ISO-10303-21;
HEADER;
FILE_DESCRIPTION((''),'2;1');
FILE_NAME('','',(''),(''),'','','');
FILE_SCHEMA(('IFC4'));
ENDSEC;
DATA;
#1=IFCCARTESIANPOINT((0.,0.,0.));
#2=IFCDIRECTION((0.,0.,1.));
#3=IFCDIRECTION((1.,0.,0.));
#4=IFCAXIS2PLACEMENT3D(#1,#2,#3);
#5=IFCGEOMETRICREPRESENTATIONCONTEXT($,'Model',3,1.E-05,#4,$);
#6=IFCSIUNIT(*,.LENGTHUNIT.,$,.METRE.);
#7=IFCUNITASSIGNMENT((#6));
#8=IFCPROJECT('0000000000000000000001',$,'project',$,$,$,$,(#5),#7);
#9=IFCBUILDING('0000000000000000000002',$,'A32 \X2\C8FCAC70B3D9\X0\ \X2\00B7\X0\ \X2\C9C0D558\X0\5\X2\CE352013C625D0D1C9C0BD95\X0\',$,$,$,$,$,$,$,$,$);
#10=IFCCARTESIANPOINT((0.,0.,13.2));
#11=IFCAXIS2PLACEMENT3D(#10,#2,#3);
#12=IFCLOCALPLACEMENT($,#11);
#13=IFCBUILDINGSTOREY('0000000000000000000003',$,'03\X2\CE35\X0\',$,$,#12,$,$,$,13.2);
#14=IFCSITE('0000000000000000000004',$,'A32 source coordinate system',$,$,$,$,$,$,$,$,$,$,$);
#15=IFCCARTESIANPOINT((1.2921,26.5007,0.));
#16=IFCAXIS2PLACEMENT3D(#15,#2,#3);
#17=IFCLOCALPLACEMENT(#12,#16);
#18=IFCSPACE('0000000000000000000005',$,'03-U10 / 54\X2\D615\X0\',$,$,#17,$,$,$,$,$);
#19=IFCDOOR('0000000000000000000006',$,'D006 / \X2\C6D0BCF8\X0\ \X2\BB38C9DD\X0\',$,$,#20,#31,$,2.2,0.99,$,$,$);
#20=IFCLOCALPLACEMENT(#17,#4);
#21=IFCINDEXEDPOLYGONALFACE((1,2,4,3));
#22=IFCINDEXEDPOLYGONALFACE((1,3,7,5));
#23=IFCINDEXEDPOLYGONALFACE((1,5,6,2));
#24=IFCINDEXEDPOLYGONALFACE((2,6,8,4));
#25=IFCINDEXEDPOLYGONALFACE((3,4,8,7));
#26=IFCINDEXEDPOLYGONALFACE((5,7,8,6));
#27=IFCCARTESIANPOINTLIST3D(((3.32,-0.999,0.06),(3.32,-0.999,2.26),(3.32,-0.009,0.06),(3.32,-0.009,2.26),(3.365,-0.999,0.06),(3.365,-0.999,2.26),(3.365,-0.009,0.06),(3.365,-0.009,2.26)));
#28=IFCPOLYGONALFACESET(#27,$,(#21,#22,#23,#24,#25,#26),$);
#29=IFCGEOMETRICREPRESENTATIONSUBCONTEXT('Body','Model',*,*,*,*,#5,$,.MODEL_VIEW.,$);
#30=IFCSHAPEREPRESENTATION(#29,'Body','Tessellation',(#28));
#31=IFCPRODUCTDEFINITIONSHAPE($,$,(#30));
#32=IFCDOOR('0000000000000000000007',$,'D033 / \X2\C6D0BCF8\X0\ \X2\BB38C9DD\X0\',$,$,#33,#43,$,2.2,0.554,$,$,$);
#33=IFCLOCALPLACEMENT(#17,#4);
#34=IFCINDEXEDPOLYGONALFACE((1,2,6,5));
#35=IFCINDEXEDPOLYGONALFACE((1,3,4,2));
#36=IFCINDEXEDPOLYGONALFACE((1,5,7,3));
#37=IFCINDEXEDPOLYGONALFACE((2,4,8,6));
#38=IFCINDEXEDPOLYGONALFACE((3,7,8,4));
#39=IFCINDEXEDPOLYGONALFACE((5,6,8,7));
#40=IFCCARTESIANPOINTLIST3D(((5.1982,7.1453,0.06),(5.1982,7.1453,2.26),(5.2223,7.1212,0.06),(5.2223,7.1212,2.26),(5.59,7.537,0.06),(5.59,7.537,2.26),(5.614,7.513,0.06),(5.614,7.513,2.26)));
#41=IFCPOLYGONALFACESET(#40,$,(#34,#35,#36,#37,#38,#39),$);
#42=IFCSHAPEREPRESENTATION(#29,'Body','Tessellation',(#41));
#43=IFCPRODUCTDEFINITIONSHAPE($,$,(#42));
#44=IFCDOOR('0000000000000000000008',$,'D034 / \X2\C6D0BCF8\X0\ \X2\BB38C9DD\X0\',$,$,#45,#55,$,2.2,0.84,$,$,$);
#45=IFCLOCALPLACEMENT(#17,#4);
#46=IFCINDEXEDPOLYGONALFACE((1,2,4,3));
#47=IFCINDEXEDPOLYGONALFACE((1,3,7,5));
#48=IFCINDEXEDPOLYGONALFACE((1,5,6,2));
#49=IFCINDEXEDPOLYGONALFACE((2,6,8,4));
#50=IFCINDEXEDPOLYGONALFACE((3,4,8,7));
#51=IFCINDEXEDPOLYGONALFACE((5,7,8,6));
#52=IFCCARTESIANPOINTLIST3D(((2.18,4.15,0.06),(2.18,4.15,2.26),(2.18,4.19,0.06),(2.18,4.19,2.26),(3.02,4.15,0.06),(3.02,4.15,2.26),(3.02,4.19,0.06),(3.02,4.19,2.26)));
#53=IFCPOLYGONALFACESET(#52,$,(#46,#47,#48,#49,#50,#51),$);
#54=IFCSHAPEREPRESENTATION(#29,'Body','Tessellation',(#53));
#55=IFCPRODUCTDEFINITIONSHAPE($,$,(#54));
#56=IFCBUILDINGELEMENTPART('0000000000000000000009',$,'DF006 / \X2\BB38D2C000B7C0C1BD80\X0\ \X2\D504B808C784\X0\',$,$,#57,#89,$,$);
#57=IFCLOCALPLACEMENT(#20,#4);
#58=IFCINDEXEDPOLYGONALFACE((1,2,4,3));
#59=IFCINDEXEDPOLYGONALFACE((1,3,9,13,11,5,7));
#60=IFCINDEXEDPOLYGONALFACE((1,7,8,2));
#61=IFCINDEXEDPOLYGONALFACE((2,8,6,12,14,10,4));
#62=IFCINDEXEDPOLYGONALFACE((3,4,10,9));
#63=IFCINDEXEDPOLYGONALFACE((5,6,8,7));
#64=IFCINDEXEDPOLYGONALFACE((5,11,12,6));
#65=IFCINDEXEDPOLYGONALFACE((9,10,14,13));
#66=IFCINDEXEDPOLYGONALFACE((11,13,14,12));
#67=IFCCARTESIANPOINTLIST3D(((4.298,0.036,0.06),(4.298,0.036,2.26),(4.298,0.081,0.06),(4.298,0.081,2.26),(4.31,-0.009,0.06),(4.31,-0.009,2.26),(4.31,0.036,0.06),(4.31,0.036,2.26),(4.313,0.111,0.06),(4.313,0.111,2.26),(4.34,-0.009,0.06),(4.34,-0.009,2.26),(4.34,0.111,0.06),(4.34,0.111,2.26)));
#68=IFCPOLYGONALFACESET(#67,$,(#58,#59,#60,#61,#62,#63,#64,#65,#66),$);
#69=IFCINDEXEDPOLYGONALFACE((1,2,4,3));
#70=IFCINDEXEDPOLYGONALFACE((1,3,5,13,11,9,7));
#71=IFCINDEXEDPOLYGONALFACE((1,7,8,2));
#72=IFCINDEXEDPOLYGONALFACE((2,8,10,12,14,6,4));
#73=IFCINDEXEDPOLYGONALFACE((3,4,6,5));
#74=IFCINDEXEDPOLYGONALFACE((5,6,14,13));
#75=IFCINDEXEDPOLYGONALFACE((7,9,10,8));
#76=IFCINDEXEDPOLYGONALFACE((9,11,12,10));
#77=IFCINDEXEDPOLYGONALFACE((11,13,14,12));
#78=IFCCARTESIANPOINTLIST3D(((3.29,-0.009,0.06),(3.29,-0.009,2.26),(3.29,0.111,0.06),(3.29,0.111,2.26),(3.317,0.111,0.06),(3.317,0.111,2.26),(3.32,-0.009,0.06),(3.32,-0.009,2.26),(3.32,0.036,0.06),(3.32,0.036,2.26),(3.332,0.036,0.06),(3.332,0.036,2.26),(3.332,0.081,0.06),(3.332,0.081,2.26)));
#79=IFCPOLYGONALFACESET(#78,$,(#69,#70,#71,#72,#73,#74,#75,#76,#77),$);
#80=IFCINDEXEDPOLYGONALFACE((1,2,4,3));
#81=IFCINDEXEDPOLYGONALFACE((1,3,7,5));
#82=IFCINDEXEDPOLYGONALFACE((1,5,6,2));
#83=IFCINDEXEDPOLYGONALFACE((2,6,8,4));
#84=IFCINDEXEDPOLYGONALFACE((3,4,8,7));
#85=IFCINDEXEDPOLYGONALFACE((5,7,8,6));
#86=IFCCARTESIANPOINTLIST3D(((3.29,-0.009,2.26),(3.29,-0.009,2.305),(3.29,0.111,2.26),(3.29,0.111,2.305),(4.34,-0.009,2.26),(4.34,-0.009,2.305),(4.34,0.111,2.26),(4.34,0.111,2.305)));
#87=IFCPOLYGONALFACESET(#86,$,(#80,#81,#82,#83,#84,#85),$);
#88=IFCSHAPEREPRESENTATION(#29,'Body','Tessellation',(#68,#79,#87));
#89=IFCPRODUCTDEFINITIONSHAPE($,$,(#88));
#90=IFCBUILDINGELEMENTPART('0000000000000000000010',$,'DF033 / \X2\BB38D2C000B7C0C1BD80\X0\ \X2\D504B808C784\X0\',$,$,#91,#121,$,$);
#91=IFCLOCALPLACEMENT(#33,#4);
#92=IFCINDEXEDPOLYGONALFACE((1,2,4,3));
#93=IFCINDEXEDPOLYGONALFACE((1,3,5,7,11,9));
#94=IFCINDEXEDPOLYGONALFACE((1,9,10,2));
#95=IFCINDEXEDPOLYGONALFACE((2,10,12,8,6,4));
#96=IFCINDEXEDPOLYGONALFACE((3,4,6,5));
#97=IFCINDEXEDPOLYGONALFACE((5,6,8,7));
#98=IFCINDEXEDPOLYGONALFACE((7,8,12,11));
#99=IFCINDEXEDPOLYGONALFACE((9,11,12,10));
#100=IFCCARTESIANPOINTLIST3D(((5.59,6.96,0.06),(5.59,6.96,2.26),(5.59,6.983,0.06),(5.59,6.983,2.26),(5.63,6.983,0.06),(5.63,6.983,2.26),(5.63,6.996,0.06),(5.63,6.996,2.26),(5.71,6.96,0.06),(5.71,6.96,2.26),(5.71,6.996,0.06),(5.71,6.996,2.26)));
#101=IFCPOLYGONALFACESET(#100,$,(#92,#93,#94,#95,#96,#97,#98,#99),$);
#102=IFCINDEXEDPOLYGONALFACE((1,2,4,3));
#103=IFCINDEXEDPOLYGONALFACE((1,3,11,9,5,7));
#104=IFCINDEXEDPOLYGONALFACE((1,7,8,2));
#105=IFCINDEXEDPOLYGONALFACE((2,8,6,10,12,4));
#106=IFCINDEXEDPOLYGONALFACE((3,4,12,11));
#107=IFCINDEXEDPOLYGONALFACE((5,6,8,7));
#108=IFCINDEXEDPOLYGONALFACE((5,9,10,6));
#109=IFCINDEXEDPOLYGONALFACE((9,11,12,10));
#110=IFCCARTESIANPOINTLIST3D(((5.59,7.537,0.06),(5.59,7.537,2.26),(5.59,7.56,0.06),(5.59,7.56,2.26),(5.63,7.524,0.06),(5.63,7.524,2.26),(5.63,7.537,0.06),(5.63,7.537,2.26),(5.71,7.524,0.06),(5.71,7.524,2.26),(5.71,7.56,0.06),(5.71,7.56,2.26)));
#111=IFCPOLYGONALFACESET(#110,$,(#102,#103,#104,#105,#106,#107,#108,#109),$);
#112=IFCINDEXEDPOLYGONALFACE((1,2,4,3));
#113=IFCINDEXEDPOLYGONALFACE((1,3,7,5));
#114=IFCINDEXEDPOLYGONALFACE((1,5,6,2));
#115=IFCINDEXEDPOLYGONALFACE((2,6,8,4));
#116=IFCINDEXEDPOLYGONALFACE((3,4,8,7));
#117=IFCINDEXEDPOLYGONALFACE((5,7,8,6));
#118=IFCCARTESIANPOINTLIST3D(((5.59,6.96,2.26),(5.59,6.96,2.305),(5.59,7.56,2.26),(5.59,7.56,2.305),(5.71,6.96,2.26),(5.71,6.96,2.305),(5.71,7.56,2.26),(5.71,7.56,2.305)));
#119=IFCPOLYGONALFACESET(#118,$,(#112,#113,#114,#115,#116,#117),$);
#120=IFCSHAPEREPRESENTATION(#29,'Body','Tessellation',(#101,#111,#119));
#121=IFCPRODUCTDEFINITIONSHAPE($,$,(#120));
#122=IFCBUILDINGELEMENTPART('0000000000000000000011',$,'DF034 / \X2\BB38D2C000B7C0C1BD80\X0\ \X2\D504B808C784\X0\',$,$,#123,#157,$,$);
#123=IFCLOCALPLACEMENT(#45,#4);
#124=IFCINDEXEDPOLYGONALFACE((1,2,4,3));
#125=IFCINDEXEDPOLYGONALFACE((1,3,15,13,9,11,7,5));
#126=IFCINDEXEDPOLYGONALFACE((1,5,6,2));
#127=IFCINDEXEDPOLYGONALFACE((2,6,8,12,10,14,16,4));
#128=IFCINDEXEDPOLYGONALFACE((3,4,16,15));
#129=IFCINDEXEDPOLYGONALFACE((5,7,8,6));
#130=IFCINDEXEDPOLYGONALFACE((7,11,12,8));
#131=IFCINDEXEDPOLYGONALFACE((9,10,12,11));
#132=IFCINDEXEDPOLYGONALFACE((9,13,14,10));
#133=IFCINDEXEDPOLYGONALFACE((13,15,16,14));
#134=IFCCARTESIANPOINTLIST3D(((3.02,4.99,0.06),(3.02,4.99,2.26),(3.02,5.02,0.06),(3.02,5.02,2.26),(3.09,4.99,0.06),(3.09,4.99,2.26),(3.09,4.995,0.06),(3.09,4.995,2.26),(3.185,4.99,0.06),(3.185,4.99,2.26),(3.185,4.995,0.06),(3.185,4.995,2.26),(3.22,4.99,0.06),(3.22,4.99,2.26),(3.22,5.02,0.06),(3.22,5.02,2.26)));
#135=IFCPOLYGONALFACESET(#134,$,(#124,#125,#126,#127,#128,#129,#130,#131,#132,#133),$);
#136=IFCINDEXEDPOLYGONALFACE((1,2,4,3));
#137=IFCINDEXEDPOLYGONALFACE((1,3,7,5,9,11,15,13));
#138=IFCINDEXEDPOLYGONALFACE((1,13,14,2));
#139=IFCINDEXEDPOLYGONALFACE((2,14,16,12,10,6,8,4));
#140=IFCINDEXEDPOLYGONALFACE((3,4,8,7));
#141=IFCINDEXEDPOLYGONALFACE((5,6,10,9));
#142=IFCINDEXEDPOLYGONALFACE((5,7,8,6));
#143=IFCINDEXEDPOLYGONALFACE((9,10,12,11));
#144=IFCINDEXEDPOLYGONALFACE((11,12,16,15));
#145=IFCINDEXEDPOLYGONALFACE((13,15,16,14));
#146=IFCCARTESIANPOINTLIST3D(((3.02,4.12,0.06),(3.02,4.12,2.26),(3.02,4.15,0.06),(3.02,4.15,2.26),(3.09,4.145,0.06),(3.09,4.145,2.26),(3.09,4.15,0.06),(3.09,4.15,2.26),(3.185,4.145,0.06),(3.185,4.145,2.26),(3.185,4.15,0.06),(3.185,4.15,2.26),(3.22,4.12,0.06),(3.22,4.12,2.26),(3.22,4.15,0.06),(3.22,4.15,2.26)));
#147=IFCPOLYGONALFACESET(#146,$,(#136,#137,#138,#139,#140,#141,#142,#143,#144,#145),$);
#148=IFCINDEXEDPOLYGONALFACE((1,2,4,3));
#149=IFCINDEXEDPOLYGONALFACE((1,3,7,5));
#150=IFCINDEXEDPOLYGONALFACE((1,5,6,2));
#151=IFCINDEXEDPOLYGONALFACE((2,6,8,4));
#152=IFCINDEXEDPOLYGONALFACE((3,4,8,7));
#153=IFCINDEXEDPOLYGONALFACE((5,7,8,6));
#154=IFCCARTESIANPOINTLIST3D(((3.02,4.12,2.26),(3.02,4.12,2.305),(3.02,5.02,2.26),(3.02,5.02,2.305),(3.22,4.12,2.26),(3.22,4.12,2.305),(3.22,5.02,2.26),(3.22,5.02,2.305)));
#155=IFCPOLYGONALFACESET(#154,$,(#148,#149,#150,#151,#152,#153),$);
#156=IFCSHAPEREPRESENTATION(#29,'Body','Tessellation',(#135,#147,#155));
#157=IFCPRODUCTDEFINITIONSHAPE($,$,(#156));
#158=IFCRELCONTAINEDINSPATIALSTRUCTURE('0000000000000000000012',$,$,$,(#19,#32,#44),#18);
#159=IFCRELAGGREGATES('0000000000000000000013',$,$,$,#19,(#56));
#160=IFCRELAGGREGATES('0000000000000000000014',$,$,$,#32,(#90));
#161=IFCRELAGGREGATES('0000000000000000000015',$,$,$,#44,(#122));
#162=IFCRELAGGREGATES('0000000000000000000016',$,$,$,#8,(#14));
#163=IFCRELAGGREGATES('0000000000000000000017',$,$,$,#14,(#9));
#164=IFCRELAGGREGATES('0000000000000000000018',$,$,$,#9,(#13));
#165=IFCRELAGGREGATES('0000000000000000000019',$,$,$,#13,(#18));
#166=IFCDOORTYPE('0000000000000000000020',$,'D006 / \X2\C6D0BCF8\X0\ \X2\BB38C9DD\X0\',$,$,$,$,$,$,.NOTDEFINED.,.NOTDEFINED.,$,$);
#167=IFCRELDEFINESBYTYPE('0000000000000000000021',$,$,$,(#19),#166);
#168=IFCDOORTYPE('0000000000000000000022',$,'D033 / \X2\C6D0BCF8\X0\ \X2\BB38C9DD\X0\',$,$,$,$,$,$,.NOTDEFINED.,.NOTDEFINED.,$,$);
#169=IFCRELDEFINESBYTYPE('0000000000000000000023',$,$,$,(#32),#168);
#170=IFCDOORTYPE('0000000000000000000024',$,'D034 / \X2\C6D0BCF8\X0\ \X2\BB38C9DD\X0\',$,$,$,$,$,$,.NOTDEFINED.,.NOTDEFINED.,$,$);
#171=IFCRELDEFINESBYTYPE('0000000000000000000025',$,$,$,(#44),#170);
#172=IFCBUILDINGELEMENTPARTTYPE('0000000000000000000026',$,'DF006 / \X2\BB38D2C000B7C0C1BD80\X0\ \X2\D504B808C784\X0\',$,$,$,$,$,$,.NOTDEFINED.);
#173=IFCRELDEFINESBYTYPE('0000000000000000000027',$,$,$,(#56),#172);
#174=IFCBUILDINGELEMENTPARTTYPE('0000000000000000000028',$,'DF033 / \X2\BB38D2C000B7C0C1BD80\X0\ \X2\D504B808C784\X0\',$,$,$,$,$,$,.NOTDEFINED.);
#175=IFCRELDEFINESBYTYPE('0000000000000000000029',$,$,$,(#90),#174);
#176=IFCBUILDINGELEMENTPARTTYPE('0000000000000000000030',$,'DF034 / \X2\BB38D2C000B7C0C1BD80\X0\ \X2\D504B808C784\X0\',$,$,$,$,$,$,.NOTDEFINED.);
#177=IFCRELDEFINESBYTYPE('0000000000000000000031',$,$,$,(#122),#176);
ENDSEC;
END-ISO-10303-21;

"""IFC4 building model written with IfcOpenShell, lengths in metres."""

from ifc_helpers import new_model, si_unit, frame, origin, origin_with_axes, place, context, subcontext, project, spatial, polyline, outline, extrude, source, transform, mapped, type_object, type_shapes, element, aggregate, save


model = new_model("IFC4")

# Units and contexts
model_context = context("Model", 3, precision=1e-05, world=origin_with_axes())
body_context = subcontext(model_context, "Body", "Model", "MODEL_VIEW")
ifc_project = project(units=[si_unit("LENGTHUNIT", "METRE")], contexts=[model_context])

# Site, building, storey, space
storey_placement = place(None, frame((0.0, 0.0, 13.2), z_axis=(0.0, 0.0, 1.0), x_axis=(1.0, 0.0, 0.0)))
space_1_placement = place(storey_placement, frame((1.2921, 26.5007, 0.0), z_axis=(0.0, 0.0, 1.0), x_axis=(1.0, 0.0, 0.0)))
site = spatial("IfcSite", under=ifc_project, Name="A32 source coordinate system")
building = spatial("IfcBuilding", under=site, Name="A32 주거동 · 지하5층–옥탑지붕")
storey = spatial("IfcBuildingStorey", under=building, at=storey_placement, Name="03층", Elevation=13.2)
space_1 = spatial("IfcSpace", under=storey, at=space_1_placement, Name="03-U10 / 54형")

# Doors
door_type_1 = type_object("IfcDoorType", Name="D006 / 원본 문짝", OperationType="NOTDEFINED", PredefinedType="NOTDEFINED")
shared_shape_1 = source(origin(), body_context, "Body", "SweptSolid", [
    extrude(outline(polyline([(3.365, -0.999), (3.32, -0.999), (3.32, -0.009), (3.365, -0.009), (3.365, -0.999)])), frame((0.0, 0.0, 0.06)), (0.0, 0.0, 1.0), 2.2),
])
type_shapes(door_type_1, [shared_shape_1])
door_1_placement = place(space_1_placement, origin_with_axes())
door_1 = element("IfcDoor", 1, at=door_1_placement, inside=space_1, type_object=door_type_1, Name="D006 / 원본 문짝", OverallHeight=2.2, OverallWidth=0.99, context=body_context, shape_type="MappedRepresentation", body=[
    mapped(shared_shape_1, transform((0.0, 0.0, 0.0), scale=1.0)),
])
door_type_2 = type_object("IfcDoorType", Name="D033 / 원본 문짝", OperationType="NOTDEFINED", PredefinedType="NOTDEFINED")
shared_shape_2 = source(origin(), body_context, "Body", "SweptSolid", [
    extrude(outline(polyline([(5.2223, 7.1212), (5.1982, 7.1453), (5.59, 7.537), (5.614, 7.513), (5.2223, 7.1212)])), frame((0.0, 0.0, 0.06)), (0.0, 0.0, 1.0), 2.2),
])
type_shapes(door_type_2, [shared_shape_2])
door_2_placement = place(space_1_placement, origin_with_axes())
door_2 = element("IfcDoor", 2, at=door_2_placement, inside=space_1, type_object=door_type_2, Name="D033 / 원본 문짝", OverallHeight=2.2, OverallWidth=0.554, context=body_context, shape_type="MappedRepresentation", body=[
    mapped(shared_shape_2, transform((0.0, 0.0, 0.0), scale=1.0)),
])
door_type_3 = type_object("IfcDoorType", Name="D034 / 원본 문짝", OperationType="NOTDEFINED", PredefinedType="NOTDEFINED")
shared_shape_3 = source(origin(), body_context, "Body", "SweptSolid", [
    extrude(outline(polyline([(3.02, 4.15), (2.18, 4.15), (2.18, 4.19), (3.02, 4.19), (3.02, 4.15)])), frame((0.0, 0.0, 0.06)), (0.0, 0.0, 1.0), 2.2),
])
type_shapes(door_type_3, [shared_shape_3])
door_3_placement = place(space_1_placement, origin_with_axes())
door_3 = element("IfcDoor", 3, at=door_3_placement, inside=space_1, type_object=door_type_3, Name="D034 / 원본 문짝", OverallHeight=2.2, OverallWidth=0.84, context=body_context, shape_type="MappedRepresentation", body=[
    mapped(shared_shape_3, transform((0.0, 0.0, 0.0), scale=1.0)),
])

# Building element parts
building_element_part_type_1 = type_object("IfcBuildingElementPartType", Name="DF006 / 문틀·상부 프레임", PredefinedType="NOTDEFINED")
shared_shape_4 = source(origin(), body_context, "Body", "SweptSolid", [
    extrude(outline(polyline([(4.31, -0.009), (4.31, 0.036), (4.298, 0.036), (4.298, 0.081), (4.313, 0.111), (4.34, 0.111), (4.34, -0.009), (4.31, -0.009)])), frame((0.0, 0.0, 0.06)), (0.0, 0.0, 1.0), 2.2),
    extrude(outline(polyline([(3.29, 0.111), (3.317, 0.111), (3.332, 0.081), (3.332, 0.036), (3.32, 0.036), (3.32, -0.009), (3.29, -0.009), (3.29, 0.111)])), frame((0.0, 0.0, 0.06)), (0.0, 0.0, 1.0), 2.2),
    extrude(outline(polyline([(3.29, -0.009), (3.29, 0.111), (4.34, 0.111), (4.34, -0.009), (3.29, -0.009)])), frame((0.0, 0.0, 2.26)), (0.0, 0.0, 1.0), 0.045),
])
type_shapes(building_element_part_type_1, [shared_shape_4])
building_element_part_1_placement = place(door_1_placement, origin_with_axes())
building_element_part_1 = element("IfcBuildingElementPart", 4, at=building_element_part_1_placement, type_object=building_element_part_type_1, Name="DF006 / 문틀·상부 프레임", context=body_context, shape_type="MappedRepresentation", body=[
    mapped(shared_shape_4, transform((0.0, 0.0, 0.0), scale=1.0)),
])
aggregate(door_1, [building_element_part_1])
building_element_part_type_2 = type_object("IfcBuildingElementPartType", Name="DF033 / 문틀·상부 프레임", PredefinedType="NOTDEFINED")
shared_shape_5 = source(origin(), body_context, "Body", "SweptSolid", [
    extrude(outline(polyline([(5.59, 6.96), (5.59, 6.983), (5.63, 6.983), (5.63, 6.996), (5.71, 6.996), (5.71, 6.96), (5.59, 6.96)])), frame((0.0, 0.0, 0.06)), (0.0, 0.0, 1.0), 2.2),
    extrude(outline(polyline([(5.71, 7.524), (5.63, 7.524), (5.63, 7.537), (5.59, 7.537), (5.59, 7.56), (5.71, 7.56), (5.71, 7.524)])), frame((0.0, 0.0, 0.06)), (0.0, 0.0, 1.0), 2.2),
    extrude(outline(polyline([(5.59, 6.96), (5.59, 7.56), (5.71, 7.56), (5.71, 6.96), (5.59, 6.96)])), frame((0.0, 0.0, 2.26)), (0.0, 0.0, 1.0), 0.045),
])
type_shapes(building_element_part_type_2, [shared_shape_5])
building_element_part_2_placement = place(door_2_placement, origin_with_axes())
building_element_part_2 = element("IfcBuildingElementPart", 5, at=building_element_part_2_placement, type_object=building_element_part_type_2, Name="DF033 / 문틀·상부 프레임", context=body_context, shape_type="MappedRepresentation", body=[
    mapped(shared_shape_5, transform((0.0, 0.0, 0.0), scale=1.0)),
])
aggregate(door_2, [building_element_part_2])
building_element_part_type_3 = type_object("IfcBuildingElementPartType", Name="DF034 / 문틀·상부 프레임", PredefinedType="NOTDEFINED")
shared_shape_6 = source(origin(), body_context, "Body", "SweptSolid", [
    extrude(outline(polyline([(3.22, 5.02), (3.22, 4.99), (3.185, 4.99), (3.185, 4.995), (3.09, 4.995), (3.09, 4.99), (3.02, 4.99), (3.02, 5.02), (3.22, 5.02)])), frame((0.0, 0.0, 0.06)), (0.0, 0.0, 1.0), 2.2),
    extrude(outline(polyline([(3.02, 4.15), (3.09, 4.15), (3.09, 4.145), (3.185, 4.145), (3.185, 4.15), (3.22, 4.15), (3.22, 4.12), (3.02, 4.12), (3.02, 4.15)])), frame((0.0, 0.0, 0.06)), (0.0, 0.0, 1.0), 2.2),
    extrude(outline(polyline([(3.02, 4.12), (3.02, 5.02), (3.22, 5.02), (3.22, 4.12), (3.02, 4.12)])), frame((0.0, 0.0, 2.26)), (0.0, 0.0, 1.0), 0.045),
])
type_shapes(building_element_part_type_3, [shared_shape_6])
building_element_part_3_placement = place(door_3_placement, origin_with_axes())
building_element_part_3 = element("IfcBuildingElementPart", 6, at=building_element_part_3_placement, type_object=building_element_part_type_3, Name="DF034 / 문틀·상부 프레임", context=body_context, shape_type="MappedRepresentation", body=[
    mapped(shared_shape_6, transform((0.0, 0.0, 0.0), scale=1.0)),
])
aggregate(door_3, [building_element_part_3])

save(model, "model.ifc")
